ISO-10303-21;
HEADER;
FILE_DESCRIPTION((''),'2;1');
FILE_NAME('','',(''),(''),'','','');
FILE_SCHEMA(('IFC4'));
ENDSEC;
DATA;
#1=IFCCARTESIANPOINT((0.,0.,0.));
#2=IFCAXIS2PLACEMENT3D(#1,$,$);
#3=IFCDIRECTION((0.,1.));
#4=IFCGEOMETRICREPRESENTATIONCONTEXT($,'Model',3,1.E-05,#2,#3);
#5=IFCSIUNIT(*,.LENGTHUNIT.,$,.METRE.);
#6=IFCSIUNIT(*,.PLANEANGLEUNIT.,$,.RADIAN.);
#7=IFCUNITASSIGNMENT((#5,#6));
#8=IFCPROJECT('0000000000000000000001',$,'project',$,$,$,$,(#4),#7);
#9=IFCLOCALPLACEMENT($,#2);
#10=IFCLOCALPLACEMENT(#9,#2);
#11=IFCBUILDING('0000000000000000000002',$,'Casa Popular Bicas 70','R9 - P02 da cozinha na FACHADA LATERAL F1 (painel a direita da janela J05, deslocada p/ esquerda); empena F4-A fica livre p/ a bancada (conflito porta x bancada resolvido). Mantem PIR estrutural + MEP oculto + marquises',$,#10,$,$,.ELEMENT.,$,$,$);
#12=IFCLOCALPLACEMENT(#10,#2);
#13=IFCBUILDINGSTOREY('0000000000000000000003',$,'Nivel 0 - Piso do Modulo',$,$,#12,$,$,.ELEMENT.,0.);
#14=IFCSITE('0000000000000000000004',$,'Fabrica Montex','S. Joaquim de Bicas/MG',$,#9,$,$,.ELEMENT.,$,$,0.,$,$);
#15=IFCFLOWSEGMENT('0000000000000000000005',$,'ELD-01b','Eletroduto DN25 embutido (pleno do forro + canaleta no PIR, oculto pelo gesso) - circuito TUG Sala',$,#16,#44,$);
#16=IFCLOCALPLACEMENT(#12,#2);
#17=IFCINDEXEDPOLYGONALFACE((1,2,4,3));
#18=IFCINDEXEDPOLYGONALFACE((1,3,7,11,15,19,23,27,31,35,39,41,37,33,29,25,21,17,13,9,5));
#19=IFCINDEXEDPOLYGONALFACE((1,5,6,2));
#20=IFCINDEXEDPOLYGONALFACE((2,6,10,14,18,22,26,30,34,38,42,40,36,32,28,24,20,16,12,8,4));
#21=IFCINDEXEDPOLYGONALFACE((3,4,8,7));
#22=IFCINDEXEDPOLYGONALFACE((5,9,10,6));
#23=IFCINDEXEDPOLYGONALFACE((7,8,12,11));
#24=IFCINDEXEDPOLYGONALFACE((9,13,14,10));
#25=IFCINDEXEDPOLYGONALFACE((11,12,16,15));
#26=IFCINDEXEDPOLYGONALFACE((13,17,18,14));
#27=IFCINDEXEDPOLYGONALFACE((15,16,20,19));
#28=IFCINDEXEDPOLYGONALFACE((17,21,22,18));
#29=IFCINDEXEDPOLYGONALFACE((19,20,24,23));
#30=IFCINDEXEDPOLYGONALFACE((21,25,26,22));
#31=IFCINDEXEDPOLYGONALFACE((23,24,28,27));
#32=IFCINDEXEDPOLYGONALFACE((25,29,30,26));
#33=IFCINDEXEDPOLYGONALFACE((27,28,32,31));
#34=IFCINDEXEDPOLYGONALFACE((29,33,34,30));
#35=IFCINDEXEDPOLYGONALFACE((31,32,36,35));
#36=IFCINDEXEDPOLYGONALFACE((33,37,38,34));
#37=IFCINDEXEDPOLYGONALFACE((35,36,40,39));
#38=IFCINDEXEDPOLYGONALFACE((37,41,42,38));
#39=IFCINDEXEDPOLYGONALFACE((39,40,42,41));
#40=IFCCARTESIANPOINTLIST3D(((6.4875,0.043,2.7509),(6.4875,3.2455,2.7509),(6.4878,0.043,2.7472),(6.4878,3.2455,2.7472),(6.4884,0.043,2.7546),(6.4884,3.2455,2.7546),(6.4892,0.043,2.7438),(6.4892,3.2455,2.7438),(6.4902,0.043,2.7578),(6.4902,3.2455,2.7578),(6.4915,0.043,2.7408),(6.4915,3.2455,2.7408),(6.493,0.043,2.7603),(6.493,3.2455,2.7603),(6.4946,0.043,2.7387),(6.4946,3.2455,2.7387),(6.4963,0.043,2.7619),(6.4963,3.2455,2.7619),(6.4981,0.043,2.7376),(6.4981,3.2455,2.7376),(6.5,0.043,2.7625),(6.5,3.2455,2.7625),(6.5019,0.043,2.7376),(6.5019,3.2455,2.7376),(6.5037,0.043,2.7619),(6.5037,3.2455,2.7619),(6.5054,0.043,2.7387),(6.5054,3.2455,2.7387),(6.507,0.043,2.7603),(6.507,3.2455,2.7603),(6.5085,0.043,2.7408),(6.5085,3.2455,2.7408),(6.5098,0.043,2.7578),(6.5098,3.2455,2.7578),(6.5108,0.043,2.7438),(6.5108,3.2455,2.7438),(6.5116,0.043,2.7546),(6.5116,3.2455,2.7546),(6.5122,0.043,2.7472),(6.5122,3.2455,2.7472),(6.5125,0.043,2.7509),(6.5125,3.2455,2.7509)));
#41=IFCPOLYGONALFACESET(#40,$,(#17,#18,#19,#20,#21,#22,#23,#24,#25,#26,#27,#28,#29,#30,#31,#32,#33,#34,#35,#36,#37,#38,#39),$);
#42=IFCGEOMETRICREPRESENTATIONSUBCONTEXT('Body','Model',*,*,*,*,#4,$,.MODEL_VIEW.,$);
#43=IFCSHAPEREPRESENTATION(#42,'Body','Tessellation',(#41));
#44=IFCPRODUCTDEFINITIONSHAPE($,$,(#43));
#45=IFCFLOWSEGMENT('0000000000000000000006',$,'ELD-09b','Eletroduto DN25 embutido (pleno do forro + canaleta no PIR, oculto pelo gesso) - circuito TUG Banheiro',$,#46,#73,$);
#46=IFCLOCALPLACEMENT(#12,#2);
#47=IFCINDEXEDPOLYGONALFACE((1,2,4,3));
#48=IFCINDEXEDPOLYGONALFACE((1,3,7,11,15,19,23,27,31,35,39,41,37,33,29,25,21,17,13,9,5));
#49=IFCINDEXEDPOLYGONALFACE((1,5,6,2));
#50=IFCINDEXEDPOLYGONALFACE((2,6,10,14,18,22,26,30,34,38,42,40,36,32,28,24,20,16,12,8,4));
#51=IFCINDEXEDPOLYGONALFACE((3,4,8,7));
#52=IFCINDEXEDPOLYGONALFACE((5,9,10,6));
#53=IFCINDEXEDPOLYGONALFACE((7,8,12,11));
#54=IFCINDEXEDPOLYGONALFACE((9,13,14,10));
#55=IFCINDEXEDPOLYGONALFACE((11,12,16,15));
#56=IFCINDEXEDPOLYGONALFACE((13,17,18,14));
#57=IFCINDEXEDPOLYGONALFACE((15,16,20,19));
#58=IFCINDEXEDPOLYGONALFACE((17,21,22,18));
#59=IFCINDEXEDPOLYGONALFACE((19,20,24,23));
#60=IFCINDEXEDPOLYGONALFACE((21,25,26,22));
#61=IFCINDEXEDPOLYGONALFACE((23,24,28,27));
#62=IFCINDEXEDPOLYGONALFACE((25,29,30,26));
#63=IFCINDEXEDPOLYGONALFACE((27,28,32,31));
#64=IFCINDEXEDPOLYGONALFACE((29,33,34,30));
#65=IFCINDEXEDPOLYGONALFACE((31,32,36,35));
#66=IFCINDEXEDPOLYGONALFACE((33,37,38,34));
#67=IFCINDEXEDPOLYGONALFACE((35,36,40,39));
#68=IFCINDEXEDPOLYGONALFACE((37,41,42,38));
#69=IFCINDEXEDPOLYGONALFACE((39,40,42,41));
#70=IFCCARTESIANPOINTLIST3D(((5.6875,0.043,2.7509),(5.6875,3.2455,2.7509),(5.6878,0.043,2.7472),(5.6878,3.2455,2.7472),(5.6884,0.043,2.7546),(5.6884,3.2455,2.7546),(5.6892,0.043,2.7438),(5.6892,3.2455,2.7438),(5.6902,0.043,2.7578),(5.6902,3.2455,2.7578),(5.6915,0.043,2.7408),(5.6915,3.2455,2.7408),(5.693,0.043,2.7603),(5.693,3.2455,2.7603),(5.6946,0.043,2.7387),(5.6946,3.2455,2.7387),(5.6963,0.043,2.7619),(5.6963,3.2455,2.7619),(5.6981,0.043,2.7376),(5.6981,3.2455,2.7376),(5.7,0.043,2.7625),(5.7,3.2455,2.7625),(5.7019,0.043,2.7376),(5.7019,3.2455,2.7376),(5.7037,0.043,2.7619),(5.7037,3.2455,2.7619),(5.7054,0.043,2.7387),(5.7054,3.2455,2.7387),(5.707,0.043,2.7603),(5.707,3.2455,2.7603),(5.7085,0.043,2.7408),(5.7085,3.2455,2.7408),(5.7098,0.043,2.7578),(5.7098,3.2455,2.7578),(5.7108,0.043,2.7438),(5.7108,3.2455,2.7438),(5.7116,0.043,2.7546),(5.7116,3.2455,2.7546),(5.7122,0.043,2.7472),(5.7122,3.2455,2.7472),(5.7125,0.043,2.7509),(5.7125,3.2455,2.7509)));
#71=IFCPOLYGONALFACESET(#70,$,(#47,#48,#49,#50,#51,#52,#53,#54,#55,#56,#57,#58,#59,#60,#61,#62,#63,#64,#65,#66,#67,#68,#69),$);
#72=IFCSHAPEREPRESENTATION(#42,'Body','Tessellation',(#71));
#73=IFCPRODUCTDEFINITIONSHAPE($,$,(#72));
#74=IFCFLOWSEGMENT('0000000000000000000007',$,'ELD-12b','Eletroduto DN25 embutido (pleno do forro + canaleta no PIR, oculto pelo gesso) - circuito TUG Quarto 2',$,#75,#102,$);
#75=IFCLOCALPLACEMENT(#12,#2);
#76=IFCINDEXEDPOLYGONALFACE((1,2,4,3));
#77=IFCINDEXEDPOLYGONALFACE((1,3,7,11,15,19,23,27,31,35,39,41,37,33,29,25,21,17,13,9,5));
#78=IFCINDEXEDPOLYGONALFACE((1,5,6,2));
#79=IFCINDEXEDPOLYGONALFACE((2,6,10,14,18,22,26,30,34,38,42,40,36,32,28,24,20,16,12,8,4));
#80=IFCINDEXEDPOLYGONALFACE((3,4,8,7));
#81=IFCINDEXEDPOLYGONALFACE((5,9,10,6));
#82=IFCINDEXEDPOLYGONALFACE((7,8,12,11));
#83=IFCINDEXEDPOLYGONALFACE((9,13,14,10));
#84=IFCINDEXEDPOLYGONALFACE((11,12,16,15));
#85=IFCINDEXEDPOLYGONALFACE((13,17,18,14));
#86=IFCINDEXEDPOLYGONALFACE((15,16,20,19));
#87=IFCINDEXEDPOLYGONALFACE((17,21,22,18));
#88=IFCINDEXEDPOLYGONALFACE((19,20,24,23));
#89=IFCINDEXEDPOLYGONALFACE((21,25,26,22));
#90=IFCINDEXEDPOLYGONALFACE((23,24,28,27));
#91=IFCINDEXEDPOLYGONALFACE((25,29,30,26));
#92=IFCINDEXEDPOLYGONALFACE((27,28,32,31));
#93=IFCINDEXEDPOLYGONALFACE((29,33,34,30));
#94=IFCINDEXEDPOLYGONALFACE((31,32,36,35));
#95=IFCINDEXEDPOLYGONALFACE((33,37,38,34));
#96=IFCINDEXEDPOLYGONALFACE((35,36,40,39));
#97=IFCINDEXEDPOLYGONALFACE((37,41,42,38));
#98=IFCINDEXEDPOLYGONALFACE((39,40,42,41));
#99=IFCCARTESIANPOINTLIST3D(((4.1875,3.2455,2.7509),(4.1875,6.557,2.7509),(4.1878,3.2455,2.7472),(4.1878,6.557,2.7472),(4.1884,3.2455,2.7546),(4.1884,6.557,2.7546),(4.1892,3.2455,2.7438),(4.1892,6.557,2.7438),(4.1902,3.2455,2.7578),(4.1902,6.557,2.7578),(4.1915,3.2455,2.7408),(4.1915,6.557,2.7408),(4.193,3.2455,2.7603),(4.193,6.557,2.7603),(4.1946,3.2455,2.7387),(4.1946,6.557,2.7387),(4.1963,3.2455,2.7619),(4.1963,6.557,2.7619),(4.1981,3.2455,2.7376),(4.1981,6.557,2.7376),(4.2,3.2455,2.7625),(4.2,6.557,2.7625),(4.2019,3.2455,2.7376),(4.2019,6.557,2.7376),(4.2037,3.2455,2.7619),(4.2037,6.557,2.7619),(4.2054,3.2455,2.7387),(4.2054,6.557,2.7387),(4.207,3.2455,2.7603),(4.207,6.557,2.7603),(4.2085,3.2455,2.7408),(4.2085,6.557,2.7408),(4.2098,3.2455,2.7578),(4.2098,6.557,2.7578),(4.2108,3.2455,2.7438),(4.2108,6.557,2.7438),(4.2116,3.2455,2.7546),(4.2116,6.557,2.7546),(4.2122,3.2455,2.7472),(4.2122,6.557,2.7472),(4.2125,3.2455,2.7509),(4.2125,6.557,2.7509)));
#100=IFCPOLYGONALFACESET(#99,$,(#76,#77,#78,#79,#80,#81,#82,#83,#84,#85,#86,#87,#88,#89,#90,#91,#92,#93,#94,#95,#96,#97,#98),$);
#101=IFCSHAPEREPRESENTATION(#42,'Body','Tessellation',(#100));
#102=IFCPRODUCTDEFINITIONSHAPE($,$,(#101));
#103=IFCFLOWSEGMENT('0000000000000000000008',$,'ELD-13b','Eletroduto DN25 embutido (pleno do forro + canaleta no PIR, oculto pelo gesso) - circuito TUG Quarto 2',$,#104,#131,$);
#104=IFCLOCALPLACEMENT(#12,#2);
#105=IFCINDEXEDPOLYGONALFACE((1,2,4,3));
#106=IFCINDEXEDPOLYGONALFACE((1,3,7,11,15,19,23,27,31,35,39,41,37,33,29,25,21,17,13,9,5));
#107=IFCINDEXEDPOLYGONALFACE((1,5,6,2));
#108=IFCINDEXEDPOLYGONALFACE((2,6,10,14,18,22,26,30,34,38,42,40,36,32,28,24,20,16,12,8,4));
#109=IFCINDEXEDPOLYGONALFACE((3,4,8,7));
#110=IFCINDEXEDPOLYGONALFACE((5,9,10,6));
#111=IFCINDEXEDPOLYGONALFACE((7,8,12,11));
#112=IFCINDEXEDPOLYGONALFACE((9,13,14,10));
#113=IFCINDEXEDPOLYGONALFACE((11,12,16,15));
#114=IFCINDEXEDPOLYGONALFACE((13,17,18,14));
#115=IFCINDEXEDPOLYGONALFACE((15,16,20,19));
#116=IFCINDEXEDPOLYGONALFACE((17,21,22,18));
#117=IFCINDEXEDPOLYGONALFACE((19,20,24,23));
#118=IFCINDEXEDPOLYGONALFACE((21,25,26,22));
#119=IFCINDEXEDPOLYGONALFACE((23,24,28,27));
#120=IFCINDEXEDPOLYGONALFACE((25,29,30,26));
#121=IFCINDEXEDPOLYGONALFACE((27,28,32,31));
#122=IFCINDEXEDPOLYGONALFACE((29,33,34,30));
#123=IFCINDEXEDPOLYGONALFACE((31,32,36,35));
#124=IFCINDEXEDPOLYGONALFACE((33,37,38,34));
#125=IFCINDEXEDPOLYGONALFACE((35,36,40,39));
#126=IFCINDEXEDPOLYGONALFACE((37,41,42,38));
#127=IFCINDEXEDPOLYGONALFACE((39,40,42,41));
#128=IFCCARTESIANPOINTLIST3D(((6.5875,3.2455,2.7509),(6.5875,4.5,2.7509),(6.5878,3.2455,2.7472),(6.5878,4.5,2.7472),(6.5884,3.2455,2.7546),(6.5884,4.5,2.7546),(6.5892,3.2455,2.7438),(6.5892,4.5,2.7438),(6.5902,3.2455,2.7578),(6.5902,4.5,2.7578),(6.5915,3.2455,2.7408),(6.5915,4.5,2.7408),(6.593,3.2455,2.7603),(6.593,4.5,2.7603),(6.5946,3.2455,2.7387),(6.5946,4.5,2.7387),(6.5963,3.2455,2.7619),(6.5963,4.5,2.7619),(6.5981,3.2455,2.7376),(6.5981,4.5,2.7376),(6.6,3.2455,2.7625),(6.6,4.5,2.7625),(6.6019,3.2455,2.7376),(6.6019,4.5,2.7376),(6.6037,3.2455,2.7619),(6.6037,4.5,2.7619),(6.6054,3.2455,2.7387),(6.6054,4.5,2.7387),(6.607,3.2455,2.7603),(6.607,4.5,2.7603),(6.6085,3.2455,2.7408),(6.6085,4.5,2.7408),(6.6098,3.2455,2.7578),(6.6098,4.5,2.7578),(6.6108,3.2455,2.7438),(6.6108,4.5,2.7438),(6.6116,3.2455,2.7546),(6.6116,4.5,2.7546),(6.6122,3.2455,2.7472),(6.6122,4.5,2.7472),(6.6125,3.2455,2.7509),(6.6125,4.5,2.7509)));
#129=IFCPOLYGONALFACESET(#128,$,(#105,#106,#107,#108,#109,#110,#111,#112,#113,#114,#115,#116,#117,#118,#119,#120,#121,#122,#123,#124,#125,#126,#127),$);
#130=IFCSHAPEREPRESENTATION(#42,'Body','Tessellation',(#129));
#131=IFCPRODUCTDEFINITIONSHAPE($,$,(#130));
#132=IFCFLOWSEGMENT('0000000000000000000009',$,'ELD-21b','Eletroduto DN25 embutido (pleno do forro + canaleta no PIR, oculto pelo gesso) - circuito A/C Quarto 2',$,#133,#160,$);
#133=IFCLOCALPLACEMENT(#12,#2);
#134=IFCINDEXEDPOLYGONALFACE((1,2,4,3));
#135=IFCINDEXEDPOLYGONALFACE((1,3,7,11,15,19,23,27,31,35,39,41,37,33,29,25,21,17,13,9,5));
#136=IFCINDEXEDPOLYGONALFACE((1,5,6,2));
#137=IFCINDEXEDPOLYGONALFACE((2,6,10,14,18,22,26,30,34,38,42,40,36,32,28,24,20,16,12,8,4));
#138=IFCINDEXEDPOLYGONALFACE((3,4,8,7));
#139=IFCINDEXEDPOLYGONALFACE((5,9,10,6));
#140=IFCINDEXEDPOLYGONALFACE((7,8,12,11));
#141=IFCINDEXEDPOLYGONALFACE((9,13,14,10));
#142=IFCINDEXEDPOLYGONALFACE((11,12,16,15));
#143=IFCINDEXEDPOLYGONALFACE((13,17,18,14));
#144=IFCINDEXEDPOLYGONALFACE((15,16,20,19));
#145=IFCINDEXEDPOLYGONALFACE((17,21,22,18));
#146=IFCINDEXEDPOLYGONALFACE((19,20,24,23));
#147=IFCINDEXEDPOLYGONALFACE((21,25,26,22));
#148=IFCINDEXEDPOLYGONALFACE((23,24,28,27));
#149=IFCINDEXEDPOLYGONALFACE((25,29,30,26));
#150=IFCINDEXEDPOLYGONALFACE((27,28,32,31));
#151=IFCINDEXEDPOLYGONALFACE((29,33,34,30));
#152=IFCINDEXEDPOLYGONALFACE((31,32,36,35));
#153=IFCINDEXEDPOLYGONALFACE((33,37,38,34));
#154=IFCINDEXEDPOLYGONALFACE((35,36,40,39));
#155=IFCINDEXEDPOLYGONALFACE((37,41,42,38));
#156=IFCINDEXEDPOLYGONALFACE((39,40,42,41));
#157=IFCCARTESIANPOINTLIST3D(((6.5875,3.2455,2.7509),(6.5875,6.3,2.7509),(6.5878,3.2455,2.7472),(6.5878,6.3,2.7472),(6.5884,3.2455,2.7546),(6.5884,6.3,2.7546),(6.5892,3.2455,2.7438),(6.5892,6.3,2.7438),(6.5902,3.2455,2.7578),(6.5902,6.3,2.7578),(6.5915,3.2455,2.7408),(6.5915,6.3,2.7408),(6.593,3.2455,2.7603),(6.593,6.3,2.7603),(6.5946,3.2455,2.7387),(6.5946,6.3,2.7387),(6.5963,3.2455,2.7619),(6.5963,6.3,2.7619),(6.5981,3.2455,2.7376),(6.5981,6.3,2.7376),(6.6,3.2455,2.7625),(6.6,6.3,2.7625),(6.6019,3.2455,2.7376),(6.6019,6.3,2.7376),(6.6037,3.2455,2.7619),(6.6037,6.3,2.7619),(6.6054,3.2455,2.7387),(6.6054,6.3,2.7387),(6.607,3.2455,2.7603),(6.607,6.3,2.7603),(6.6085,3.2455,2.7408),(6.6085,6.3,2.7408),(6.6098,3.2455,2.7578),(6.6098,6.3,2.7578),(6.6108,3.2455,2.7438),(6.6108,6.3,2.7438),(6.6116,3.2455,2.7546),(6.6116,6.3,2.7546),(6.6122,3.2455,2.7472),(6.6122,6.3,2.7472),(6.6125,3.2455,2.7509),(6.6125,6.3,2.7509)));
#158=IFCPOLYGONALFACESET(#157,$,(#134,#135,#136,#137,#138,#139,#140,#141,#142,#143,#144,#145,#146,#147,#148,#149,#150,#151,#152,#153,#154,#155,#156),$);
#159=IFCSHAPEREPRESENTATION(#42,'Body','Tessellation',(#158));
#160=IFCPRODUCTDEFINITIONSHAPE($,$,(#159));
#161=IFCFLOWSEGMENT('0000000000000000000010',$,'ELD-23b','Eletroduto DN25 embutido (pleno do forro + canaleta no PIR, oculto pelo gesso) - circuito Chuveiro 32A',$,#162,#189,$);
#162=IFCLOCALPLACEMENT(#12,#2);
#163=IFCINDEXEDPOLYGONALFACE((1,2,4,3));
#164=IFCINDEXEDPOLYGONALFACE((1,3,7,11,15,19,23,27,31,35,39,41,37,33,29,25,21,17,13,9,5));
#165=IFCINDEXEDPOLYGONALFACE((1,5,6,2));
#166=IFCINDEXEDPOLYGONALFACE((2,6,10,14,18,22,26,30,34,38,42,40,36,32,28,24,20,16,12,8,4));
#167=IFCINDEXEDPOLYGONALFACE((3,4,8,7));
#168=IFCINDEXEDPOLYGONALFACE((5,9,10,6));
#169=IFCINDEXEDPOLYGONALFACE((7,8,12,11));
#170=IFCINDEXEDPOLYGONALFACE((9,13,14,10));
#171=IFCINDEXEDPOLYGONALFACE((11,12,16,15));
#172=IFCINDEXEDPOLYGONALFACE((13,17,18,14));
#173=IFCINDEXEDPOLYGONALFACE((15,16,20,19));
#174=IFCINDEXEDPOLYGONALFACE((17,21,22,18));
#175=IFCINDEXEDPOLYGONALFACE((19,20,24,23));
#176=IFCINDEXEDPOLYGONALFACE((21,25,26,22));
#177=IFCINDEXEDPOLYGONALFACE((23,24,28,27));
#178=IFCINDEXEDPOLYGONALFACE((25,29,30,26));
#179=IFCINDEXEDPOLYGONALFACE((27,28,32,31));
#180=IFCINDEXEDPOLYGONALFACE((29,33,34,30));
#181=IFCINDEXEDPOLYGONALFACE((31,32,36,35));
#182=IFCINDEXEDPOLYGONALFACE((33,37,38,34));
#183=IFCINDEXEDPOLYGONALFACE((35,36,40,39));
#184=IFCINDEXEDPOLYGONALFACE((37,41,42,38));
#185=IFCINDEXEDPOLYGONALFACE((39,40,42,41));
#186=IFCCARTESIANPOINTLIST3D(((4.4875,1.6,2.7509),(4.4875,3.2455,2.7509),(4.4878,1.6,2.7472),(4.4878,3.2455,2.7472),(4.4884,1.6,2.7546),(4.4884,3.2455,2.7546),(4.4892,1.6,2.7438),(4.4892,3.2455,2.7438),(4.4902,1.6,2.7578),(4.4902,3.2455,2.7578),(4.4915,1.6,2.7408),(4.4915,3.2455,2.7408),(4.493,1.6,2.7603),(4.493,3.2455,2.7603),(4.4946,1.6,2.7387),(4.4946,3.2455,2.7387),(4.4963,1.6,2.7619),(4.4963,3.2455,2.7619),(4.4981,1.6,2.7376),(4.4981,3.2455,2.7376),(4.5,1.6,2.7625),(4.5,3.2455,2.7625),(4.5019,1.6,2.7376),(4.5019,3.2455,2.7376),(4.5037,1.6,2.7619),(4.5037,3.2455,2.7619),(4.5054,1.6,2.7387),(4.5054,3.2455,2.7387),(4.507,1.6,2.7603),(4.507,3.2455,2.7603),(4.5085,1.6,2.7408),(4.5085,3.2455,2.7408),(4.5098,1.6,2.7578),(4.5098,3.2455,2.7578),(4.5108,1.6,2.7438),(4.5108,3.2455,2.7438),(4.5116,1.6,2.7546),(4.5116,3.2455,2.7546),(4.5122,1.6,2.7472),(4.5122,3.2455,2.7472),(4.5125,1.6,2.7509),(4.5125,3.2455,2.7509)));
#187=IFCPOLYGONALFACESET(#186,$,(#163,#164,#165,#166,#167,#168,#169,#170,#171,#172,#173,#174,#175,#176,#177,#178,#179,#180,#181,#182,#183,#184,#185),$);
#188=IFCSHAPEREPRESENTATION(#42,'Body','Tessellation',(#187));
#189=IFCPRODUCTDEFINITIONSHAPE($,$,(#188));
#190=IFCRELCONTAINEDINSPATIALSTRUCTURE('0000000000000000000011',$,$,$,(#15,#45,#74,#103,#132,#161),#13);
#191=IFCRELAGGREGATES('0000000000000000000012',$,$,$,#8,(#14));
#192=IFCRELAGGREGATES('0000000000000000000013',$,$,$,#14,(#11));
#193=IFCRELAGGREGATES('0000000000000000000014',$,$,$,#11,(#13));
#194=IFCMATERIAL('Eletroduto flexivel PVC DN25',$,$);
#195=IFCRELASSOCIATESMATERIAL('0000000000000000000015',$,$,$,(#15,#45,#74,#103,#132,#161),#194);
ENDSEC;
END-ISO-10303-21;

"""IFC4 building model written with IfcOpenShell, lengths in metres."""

from ifc_helpers import new_model, si_unit, direction, frame, origin, origin_2d, place, context, subcontext, project, spatial, circle, extrude, material, element, save


model = new_model("IFC4")

# Units and contexts
model_context = context("Model", 3, precision=1e-05, world=origin(), true_north=direction((0.0, 1.0)))
body_context = subcontext(model_context, "Body", "Model", "MODEL_VIEW")
ifc_project = project(units=[si_unit("LENGTHUNIT", "METRE"), si_unit("PLANEANGLEUNIT", "RADIAN")], contexts=[model_context])

# Site, building, storey
site_placement = place(None, origin())
site = spatial("IfcSite", under=ifc_project, at=site_placement, Name="Fabrica Montex", Description="S. Joaquim de Bicas/MG", CompositionType="ELEMENT", RefElevation=0.0)
building_placement = place(site_placement, origin())
building = spatial("IfcBuilding", under=site, at=building_placement, Name="Casa Popular Bicas 70", Description="R9 - P02 da cozinha na FACHADA LATERAL F1 (painel a direita da janela J05, deslocada p/ esquerda); empena F4-A fica livre p/ a bancada (conflito porta x bancada resolvido). Mantem PIR estrutural + MEP oculto + marquises", CompositionType="ELEMENT")
storey_placement = place(building_placement, origin())
storey = spatial("IfcBuildingStorey", under=building, at=storey_placement, Name="Nivel 0 - Piso do Modulo", CompositionType="ELEMENT", Elevation=0.0)

# Flow segments
ifc_material_1 = material(Name="Eletroduto flexivel PVC DN25")
for number, where, z_axis, x_axis, name, description in (
    (1, (6.5, 3.2455, 2.75), (0.0, -1.0, 0.0), (0.0, 0.0, 1.0), "ELD-01b", "Eletroduto DN25 embutido (pleno do forro + canaleta no PIR, oculto pelo gesso) - circuito TUG Sala"),
    (2, (5.7, 3.2455, 2.75), (0.0, -1.0, 0.0), (0.0, 0.0, 1.0), "ELD-09b", "Eletroduto DN25 embutido (pleno do forro + canaleta no PIR, oculto pelo gesso) - circuito TUG Banheiro"),
):
    element("IfcFlowSegment", number, at=place(storey_placement, frame(where, z_axis=z_axis, x_axis=x_axis)), inside=storey, material=ifc_material_1, Name=name, Description=description, context=body_context, shape_type="SweptSolid", body=[
        extrude(circle(Radius=0.0125, at=origin_2d()), origin(), (0.0, 0.0, 1.0), 3.2025),
    ])
flow_segment_1_placement = place(storey_placement, frame((4.2, 3.2455, 2.75), z_axis=(0.0, 1.0, 0.0), x_axis=(0.0, 0.0, 1.0)))
element("IfcFlowSegment", 3, at=flow_segment_1_placement, inside=storey, material=ifc_material_1, Name="ELD-12b", Description="Eletroduto DN25 embutido (pleno do forro + canaleta no PIR, oculto pelo gesso) - circuito TUG Quarto 2", context=body_context, shape_type="SweptSolid", body=[
    extrude(circle(Radius=0.0125, at=origin_2d()), origin(), (0.0, 0.0, 1.0), 3.3115),
])
flow_segment_2_placement = place(storey_placement, frame((6.6, 3.2455, 2.75), z_axis=(0.0, 1.0, 0.0), x_axis=(0.0, 0.0, 1.0)))
element("IfcFlowSegment", 4, at=flow_segment_2_placement, inside=storey, material=ifc_material_1, Name="ELD-13b", Description="Eletroduto DN25 embutido (pleno do forro + canaleta no PIR, oculto pelo gesso) - circuito TUG Quarto 2", context=body_context, shape_type="SweptSolid", body=[
    extrude(circle(Radius=0.0125, at=origin_2d()), origin(), (0.0, 0.0, 1.0), 1.2545),
])
flow_segment_3_placement = place(storey_placement, frame((6.6, 3.2455, 2.75), z_axis=(0.0, 1.0, 0.0), x_axis=(0.0, 0.0, 1.0)))
element("IfcFlowSegment", 5, at=flow_segment_3_placement, inside=storey, material=ifc_material_1, Name="ELD-21b", Description="Eletroduto DN25 embutido (pleno do forro + canaleta no PIR, oculto pelo gesso) - circuito A/C Quarto 2", context=body_context, shape_type="SweptSolid", body=[
    extrude(circle(Radius=0.0125, at=origin_2d()), origin(), (0.0, 0.0, 1.0), 3.0545),
])
flow_segment_4_placement = place(storey_placement, frame((4.5, 3.2455, 2.75), z_axis=(0.0, -1.0, 0.0), x_axis=(0.0, 0.0, 1.0)))
element("IfcFlowSegment", 6, at=flow_segment_4_placement, inside=storey, material=ifc_material_1, Name="ELD-23b", Description="Eletroduto DN25 embutido (pleno do forro + canaleta no PIR, oculto pelo gesso) - circuito Chuveiro 32A", context=body_context, shape_type="SweptSolid", body=[
    extrude(circle(Radius=0.0125, at=origin_2d()), origin(), (0.0, 0.0, 1.0), 1.6455),
])

save(model, "model.ifc")
